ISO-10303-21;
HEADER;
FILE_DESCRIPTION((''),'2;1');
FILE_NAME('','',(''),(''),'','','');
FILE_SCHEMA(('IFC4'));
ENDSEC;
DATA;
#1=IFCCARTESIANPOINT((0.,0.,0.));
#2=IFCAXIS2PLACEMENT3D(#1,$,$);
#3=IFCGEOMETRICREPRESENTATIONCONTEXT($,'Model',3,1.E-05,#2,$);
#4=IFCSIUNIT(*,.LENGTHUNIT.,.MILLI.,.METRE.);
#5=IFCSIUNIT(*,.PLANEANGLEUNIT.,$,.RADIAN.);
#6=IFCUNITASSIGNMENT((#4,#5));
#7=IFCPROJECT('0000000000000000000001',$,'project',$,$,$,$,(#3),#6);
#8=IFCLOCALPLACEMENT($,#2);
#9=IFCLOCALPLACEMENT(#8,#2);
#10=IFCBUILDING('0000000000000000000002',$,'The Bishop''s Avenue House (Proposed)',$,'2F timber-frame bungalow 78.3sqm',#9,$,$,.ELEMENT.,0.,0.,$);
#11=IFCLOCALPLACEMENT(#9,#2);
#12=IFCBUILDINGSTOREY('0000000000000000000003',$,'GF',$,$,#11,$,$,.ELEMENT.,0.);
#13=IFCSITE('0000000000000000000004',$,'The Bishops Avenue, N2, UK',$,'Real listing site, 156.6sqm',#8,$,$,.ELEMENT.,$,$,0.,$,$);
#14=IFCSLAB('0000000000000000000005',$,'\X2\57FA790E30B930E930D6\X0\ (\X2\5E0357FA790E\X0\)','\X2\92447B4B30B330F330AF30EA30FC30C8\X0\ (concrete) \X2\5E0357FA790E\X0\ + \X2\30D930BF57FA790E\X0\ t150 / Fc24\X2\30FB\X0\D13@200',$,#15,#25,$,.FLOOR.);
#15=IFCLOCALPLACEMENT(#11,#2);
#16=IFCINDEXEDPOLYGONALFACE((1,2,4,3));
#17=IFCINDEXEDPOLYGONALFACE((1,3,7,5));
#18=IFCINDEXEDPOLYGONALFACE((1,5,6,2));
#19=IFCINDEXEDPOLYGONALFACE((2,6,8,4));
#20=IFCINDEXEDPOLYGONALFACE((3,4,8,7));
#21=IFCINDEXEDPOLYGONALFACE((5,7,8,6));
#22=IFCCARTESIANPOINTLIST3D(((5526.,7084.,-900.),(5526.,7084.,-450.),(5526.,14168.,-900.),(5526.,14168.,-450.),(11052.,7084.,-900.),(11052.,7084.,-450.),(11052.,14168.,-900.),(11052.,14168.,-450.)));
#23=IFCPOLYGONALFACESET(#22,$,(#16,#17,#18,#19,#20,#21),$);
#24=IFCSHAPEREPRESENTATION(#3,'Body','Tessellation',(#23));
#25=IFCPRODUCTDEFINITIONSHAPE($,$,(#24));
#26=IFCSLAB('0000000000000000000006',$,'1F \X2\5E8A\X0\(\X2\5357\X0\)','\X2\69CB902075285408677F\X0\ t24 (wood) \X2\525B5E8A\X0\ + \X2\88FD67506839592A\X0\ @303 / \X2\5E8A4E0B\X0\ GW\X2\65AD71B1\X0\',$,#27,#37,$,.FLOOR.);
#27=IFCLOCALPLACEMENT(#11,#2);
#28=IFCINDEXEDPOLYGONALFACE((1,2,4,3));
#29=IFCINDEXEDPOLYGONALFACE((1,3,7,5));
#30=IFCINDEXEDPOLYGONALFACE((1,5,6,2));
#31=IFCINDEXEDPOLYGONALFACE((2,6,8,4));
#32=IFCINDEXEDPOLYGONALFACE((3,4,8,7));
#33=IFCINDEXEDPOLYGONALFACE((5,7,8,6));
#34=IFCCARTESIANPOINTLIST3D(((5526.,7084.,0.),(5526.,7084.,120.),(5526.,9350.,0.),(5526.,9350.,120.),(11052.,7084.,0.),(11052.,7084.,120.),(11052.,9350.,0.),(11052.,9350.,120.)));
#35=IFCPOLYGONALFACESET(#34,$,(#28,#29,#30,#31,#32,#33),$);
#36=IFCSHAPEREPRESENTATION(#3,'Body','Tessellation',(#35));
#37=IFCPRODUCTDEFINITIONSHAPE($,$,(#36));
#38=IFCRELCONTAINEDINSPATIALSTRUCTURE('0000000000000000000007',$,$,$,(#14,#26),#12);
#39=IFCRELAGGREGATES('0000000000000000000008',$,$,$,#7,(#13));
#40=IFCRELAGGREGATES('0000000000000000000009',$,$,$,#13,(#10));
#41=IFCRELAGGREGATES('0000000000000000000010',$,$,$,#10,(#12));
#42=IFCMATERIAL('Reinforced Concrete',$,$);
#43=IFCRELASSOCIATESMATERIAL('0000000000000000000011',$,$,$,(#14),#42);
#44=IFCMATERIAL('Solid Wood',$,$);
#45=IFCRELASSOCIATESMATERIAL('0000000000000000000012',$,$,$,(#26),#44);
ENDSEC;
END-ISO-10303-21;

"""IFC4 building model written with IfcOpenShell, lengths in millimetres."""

from ifc_helpers import new_model, si_unit, frame, frame_2d, origin, place, context, project, spatial, rectangle, extrude, material, element, save


model = new_model("IFC4")

# Units and contexts
model_context = context("Model", 3, precision=1e-05, world=origin())
ifc_project = project(units=[si_unit("LENGTHUNIT", "METRE", prefix="MILLI"), si_unit("PLANEANGLEUNIT", "RADIAN")], contexts=[model_context])

# Site, building, storey
site_placement = place(None, origin())
site = spatial("IfcSite", under=ifc_project, at=site_placement, Name="The Bishops Avenue, N2, UK", ObjectType="Real listing site, 156.6sqm", CompositionType="ELEMENT", RefElevation=0.0)
building_placement = place(site_placement, origin())
building = spatial("IfcBuilding", under=site, at=building_placement, Name="The Bishop's Avenue House (Proposed)", ObjectType="2F timber-frame bungalow 78.3sqm", CompositionType="ELEMENT", ElevationOfRefHeight=0.0, ElevationOfTerrain=0.0)
storey_placement = place(building_placement, origin())
storey = spatial("IfcBuildingStorey", under=building, at=storey_placement, Name="GF", CompositionType="ELEMENT", Elevation=0.0)

# Slabs
ifc_material_1 = material(Name="Reinforced Concrete")
slab_1_placement = place(storey_placement, frame((2763.0, 3542.0, -450.0)))
element("IfcSlab", 1, at=slab_1_placement, inside=storey, material=ifc_material_1, Name="基礎スラブ (布基礎)", Description="鉄筋コンクリート (concrete) 布基礎 + ベタ基礎 t150 / Fc24・D13@200", PredefinedType="FLOOR", context=model_context, shape_type="SweptSolid", body=[
    extrude(rectangle(XDim=5526.0, YDim=7084.0, at=frame_2d((2763.0, 3542.0))), frame((2763.0, 3542.0, -450.0)), (0.0, 0.0, 1.0), 450.0),
])
ifc_material_2 = material(Name="Solid Wood")
slab_2_placement = place(storey_placement, frame((2763.0, 3542.0, 0.0)))
element("IfcSlab", 2, at=slab_2_placement, inside=storey, material=ifc_material_2, Name="1F 床(南)", Description="構造用合板 t24 (wood) 剛床 + 製材根太 @303 / 床下 GW断熱", PredefinedType="FLOOR", context=model_context, shape_type="SweptSolid", body=[
    extrude(rectangle(XDim=5526.0, YDim=2266.0, at=frame_2d((2763.0, 1133.0))), frame((2763.0, 3542.0, 0.0)), (0.0, 0.0, 1.0), 120.0),
])

save(model, "model.ifc")
